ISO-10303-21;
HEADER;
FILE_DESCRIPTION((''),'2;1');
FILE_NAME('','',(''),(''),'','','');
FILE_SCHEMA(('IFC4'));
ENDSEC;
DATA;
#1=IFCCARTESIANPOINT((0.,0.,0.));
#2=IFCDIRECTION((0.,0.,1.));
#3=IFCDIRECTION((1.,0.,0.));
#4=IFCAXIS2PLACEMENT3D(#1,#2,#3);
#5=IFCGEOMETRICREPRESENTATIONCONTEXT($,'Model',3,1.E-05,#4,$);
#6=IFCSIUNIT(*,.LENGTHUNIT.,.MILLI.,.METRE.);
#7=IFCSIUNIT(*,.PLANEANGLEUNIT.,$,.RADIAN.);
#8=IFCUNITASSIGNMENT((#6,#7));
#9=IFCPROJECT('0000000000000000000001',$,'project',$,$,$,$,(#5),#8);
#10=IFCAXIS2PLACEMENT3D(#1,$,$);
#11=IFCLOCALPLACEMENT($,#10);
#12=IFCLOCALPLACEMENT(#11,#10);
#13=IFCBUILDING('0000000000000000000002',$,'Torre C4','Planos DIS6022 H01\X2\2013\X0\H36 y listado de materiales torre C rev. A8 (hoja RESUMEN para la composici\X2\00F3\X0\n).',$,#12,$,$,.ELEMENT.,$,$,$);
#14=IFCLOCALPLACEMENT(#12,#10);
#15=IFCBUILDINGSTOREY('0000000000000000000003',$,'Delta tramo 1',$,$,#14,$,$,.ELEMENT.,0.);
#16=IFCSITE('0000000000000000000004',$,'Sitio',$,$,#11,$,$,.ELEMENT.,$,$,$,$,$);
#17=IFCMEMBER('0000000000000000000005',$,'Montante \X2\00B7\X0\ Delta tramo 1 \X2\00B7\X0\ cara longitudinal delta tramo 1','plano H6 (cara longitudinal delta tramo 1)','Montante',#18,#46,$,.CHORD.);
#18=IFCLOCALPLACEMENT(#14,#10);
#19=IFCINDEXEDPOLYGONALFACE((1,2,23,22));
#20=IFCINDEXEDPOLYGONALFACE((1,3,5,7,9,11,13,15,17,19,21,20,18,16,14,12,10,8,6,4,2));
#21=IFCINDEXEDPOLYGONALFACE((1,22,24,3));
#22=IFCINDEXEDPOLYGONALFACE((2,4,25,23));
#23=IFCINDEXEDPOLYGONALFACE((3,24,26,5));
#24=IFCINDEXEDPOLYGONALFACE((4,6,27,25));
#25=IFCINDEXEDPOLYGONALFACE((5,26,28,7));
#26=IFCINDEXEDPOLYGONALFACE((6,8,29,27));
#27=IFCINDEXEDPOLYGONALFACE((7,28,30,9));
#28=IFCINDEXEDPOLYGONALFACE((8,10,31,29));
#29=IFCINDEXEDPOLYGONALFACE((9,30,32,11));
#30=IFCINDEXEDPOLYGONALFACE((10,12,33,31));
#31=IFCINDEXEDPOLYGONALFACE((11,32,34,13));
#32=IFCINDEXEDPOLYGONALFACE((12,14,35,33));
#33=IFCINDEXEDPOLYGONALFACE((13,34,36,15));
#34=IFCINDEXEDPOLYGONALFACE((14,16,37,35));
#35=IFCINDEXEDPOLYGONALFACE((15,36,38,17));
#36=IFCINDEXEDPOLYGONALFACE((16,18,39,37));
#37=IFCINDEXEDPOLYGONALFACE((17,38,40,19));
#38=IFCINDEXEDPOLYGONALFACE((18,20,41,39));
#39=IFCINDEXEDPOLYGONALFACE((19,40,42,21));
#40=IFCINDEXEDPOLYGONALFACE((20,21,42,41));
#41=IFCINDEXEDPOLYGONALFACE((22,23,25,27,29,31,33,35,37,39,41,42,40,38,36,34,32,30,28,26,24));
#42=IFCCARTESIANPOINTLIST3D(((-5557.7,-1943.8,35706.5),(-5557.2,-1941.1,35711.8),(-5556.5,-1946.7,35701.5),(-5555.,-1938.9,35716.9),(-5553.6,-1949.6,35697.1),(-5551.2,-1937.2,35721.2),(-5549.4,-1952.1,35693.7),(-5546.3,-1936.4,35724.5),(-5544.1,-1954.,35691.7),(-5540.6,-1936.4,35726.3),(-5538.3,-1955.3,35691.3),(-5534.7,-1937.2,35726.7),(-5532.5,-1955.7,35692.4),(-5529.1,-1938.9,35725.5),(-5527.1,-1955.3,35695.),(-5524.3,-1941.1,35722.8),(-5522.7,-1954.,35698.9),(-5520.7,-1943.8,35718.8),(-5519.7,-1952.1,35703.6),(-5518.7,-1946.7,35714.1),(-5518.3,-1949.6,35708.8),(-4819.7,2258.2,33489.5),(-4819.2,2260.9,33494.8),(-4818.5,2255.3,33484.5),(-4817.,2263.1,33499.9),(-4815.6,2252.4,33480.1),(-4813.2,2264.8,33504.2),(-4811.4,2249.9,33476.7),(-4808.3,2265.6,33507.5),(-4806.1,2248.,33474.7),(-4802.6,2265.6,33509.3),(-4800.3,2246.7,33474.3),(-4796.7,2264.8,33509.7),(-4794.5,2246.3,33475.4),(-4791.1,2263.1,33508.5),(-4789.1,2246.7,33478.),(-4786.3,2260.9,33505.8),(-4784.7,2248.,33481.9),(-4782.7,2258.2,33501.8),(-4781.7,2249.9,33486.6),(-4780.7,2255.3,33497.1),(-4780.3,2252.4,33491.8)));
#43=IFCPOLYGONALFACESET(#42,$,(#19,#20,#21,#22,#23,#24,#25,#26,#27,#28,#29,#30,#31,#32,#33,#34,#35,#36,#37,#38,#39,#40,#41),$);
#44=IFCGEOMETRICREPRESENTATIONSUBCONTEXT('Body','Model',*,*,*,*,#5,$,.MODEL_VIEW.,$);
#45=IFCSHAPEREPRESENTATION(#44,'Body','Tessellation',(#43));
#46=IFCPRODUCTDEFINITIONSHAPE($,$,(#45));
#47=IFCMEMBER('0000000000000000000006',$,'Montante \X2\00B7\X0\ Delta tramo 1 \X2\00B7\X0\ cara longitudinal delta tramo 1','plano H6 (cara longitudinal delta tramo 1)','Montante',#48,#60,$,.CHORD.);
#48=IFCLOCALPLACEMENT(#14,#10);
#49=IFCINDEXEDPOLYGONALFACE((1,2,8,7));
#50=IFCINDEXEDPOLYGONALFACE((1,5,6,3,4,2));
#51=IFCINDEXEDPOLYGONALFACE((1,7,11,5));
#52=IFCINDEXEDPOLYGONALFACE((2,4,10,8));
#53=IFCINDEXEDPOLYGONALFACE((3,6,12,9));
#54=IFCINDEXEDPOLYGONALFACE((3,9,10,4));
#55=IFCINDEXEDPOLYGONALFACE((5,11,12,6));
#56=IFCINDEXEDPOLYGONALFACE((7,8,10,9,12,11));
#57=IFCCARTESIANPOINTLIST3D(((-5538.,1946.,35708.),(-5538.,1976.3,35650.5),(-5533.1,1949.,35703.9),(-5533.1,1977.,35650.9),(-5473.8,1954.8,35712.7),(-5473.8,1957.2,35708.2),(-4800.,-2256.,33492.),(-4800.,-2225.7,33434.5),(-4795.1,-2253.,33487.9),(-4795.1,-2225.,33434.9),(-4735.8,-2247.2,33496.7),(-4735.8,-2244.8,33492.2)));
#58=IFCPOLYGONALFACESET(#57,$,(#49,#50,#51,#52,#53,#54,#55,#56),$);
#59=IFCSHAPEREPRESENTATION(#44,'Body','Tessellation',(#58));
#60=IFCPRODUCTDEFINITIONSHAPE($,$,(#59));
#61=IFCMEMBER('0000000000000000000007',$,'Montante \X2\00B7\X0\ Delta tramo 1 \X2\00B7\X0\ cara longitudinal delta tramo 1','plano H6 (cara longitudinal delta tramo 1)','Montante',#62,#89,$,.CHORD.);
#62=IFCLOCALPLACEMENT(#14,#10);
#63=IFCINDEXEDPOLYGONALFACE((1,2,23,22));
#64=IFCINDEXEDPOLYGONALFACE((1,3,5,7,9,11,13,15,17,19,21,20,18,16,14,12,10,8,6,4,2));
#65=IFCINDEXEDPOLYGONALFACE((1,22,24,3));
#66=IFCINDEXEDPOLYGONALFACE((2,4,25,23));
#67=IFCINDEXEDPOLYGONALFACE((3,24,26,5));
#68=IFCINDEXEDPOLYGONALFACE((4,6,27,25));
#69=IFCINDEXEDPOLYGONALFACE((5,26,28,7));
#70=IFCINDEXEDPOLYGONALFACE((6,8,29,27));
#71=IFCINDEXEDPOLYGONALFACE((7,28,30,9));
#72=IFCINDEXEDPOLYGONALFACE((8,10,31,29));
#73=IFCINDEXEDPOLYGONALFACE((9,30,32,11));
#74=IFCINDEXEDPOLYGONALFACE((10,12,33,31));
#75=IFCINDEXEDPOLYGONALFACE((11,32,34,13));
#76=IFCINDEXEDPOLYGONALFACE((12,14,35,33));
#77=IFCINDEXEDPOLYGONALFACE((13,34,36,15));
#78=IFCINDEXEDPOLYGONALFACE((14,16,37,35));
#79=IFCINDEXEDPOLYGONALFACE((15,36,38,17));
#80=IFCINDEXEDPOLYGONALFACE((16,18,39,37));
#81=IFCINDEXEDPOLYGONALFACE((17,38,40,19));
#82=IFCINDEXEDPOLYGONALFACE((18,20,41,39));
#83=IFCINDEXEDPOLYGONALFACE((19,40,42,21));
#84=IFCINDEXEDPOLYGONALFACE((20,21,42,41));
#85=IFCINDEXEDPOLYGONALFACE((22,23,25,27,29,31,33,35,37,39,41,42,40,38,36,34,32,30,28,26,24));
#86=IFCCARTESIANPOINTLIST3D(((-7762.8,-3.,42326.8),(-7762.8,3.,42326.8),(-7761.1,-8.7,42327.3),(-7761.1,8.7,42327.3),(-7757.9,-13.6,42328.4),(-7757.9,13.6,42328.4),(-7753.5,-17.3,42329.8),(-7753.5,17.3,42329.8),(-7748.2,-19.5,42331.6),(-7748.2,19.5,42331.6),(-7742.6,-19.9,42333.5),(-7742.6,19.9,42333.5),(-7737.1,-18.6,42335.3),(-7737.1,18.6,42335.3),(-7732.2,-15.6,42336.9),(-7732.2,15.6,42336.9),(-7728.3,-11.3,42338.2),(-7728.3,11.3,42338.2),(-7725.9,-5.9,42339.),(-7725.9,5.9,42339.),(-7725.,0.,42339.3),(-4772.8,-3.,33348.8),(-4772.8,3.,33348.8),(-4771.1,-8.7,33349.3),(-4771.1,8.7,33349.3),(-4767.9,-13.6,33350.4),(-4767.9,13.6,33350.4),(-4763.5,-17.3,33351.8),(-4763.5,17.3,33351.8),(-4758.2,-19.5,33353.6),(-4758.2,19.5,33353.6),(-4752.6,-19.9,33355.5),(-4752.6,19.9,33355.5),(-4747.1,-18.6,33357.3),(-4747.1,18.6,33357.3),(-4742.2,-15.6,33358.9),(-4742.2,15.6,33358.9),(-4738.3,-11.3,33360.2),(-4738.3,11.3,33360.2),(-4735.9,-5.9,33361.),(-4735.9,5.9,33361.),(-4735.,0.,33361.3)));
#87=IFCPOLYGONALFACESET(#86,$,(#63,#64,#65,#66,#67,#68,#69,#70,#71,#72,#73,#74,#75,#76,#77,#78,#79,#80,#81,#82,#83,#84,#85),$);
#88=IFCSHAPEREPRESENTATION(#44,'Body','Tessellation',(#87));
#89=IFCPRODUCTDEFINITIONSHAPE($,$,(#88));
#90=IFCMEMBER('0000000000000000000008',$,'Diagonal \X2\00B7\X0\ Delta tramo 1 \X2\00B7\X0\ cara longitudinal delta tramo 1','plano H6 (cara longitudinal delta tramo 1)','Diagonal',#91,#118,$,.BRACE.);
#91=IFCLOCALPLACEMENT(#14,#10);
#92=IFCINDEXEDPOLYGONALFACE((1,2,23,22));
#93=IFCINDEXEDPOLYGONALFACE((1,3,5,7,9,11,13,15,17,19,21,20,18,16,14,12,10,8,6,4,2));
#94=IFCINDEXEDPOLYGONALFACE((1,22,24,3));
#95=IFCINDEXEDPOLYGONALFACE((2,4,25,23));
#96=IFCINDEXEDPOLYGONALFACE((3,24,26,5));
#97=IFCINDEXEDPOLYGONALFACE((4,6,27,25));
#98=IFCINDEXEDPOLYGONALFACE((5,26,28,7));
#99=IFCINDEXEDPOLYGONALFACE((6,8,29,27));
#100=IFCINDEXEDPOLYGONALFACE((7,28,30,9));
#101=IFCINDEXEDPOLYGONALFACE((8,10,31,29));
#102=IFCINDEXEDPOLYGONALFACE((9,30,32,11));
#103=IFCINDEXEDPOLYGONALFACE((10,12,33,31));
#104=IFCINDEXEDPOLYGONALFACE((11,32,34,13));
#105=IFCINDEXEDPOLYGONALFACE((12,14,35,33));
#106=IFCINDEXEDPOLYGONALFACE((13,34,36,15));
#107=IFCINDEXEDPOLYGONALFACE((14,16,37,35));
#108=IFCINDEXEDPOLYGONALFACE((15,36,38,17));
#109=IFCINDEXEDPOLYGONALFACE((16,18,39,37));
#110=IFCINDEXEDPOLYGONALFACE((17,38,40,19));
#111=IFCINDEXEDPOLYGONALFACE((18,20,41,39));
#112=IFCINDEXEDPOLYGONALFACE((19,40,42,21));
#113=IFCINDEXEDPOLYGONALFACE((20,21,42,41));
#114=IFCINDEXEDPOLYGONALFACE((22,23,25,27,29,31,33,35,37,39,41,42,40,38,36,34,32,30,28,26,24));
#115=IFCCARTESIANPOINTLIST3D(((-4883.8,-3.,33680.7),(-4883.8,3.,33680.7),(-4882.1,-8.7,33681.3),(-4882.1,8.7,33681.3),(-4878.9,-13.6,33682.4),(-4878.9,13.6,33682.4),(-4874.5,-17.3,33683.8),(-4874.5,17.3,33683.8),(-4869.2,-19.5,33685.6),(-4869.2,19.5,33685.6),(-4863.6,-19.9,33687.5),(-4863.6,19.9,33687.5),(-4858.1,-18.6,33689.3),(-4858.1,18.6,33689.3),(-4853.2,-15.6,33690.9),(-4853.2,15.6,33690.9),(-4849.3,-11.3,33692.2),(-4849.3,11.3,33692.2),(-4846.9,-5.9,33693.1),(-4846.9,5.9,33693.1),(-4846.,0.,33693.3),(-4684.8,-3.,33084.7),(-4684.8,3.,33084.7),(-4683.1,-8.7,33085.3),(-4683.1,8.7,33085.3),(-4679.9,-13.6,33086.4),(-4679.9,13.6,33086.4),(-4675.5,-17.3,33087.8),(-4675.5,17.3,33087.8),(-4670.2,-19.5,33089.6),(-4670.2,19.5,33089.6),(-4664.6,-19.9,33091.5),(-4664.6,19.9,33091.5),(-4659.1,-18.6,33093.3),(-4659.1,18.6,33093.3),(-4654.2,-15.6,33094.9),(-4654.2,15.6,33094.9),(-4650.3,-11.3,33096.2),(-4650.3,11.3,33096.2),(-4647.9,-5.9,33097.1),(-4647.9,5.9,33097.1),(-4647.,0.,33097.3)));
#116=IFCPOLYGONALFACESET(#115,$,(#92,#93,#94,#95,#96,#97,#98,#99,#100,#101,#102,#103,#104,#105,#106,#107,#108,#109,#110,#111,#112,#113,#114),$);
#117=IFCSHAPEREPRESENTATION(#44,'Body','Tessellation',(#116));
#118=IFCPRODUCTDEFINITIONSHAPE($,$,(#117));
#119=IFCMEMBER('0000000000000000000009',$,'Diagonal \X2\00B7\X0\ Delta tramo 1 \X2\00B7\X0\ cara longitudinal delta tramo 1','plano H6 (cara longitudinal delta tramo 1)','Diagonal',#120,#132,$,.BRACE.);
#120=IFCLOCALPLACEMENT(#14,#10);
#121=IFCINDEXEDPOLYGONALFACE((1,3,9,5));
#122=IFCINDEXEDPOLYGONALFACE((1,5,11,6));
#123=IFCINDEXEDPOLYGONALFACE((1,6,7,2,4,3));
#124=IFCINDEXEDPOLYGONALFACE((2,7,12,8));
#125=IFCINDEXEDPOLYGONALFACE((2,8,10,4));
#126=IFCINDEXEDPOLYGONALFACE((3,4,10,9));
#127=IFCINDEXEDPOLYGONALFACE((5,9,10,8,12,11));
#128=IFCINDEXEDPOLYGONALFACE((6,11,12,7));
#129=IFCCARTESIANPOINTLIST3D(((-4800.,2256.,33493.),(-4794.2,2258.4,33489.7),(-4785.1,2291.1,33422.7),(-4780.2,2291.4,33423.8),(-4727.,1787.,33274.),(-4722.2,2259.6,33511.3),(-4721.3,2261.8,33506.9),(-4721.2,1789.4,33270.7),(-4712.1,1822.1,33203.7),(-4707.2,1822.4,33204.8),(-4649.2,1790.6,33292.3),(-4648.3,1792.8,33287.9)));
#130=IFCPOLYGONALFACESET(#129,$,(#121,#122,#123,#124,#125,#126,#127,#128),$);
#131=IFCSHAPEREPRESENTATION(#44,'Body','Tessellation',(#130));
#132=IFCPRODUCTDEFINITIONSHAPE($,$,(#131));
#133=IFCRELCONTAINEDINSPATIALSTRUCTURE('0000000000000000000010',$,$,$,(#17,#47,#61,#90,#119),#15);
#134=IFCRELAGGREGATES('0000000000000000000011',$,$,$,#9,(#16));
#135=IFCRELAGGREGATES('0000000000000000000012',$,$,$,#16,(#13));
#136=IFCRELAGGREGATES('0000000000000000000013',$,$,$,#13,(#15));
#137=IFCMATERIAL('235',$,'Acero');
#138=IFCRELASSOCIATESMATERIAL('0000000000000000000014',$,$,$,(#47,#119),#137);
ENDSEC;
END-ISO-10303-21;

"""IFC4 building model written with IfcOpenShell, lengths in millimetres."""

from ifc_helpers import new_model, si_unit, frame, frame_2d, origin, origin_with_axes, place, context, subcontext, project, spatial, circle, l_section, extrude, material, element, save


model = new_model("IFC4")

# Units and contexts
model_context = context("Model", 3, precision=1e-05, world=origin_with_axes())
body_context = subcontext(model_context, "Body", "Model", "MODEL_VIEW")
ifc_project = project(units=[si_unit("LENGTHUNIT", "METRE", prefix="MILLI"), si_unit("PLANEANGLEUNIT", "RADIAN")], contexts=[model_context])

# Site, building, storey
site_placement = place(None, origin())
site = spatial("IfcSite", under=ifc_project, at=site_placement, Name="Sitio", CompositionType="ELEMENT")
building_placement = place(site_placement, origin())
building = spatial("IfcBuilding", under=site, at=building_placement, Name="Torre C4", Description="Planos DIS6022 H01–H36 y listado de materiales torre C rev. A8 (hoja RESUMEN para la composición).", CompositionType="ELEMENT")
storey_placement = place(building_placement, origin())
storey = spatial("IfcBuildingStorey", under=building, at=storey_placement, Name="Delta tramo 1", CompositionType="ELEMENT", Elevation=0.0)

# Members
member_1_placement = place(storey_placement, frame((-4800.0, 2256.0, 33492.0), z_axis=(-0.153495, -0.873966, 0.46111), x_axis=(0.276036, -0.485987, -0.829229)))
element("IfcMember", 1, at=member_1_placement, inside=storey, Name="Montante · Delta tramo 1 · cara longitudinal delta tramo 1", Description="plano H6 (cara longitudinal delta tramo 1)", ObjectType="Montante", PredefinedType="CHORD", context=body_context, shape_type="SweptSolid", body=[
    extrude(circle(Radius=20.0), None, (0.0, 0.0, 1.0), 4808.0),
])
ifc_material_1 = material(Name="235", Category="Acero")
member_2_placement = place(storey_placement, frame((-4800.0, -2256.0, 33492.0), z_axis=(-0.15351, 0.87405, 0.460946), x_axis=(0.988147, 0.135785, 0.071609)))
element("IfcMember", 2, at=member_2_placement, inside=storey, material=ifc_material_1, Name="Montante · Delta tramo 1 · cara longitudinal delta tramo 1", Description="plano H6 (cara longitudinal delta tramo 1)", ObjectType="Montante", PredefinedType="CHORD", context=body_context, shape_type="SweptSolid", body=[
    extrude(l_section(Depth=65.0, Width=65.0, Thickness=5.0, at=frame_2d((32.5, 32.5))), None, (0.0, 0.0, 1.0), 4807.5),
])
member_3_placement = place(storey_placement, frame((-4754.0, 0.0, 33355.0), z_axis=(-0.315974, 0.0, 0.948768), x_axis=(0.948768, 0.0, 0.315974)))
element("IfcMember", 3, at=member_3_placement, inside=storey, Name="Montante · Delta tramo 1 · cara longitudinal delta tramo 1", Description="plano H6 (cara longitudinal delta tramo 1)", ObjectType="Montante", PredefinedType="CHORD", context=body_context, shape_type="SweptSolid", body=[
    extrude(circle(Radius=20.0), None, (0.0, 0.0, 1.0), 9462.8),
])
member_4_placement = place(storey_placement, frame((-4666.0, 0.0, 33091.0), z_axis=(-0.316705, 0.0, 0.948524), x_axis=(0.948524, 0.0, 0.316705)))
element("IfcMember", 4, at=member_4_placement, inside=storey, Name="Diagonal · Delta tramo 1 · cara longitudinal delta tramo 1", Description="plano H6 (cara longitudinal delta tramo 1)", ObjectType="Diagonal", PredefinedType="BRACE", context=body_context, shape_type="SweptSolid", body=[
    extrude(circle(Radius=20.0), None, (0.0, 0.0, 1.0), 628.3),
])
member_5_placement = place(storey_placement, frame((-4727.0, 1787.0, 33274.0), z_axis=(-0.13965, 0.897206, 0.418951), x_axis=(0.972489, 0.044604, 0.22864)))
element("IfcMember", 5, at=member_5_placement, inside=storey, material=ifc_material_1, Name="Diagonal · Delta tramo 1 · cara longitudinal delta tramo 1", Description="plano H6 (cara longitudinal delta tramo 1)", ObjectType="Diagonal", PredefinedType="BRACE", context=body_context, shape_type="SweptSolid", body=[
    extrude(l_section(Depth=80.0, Width=80.0, Thickness=5.0, at=frame_2d((40.0, 40.0))), None, (0.0, 0.0, 1.0), 522.7),
])

save(model, "model.ifc")
